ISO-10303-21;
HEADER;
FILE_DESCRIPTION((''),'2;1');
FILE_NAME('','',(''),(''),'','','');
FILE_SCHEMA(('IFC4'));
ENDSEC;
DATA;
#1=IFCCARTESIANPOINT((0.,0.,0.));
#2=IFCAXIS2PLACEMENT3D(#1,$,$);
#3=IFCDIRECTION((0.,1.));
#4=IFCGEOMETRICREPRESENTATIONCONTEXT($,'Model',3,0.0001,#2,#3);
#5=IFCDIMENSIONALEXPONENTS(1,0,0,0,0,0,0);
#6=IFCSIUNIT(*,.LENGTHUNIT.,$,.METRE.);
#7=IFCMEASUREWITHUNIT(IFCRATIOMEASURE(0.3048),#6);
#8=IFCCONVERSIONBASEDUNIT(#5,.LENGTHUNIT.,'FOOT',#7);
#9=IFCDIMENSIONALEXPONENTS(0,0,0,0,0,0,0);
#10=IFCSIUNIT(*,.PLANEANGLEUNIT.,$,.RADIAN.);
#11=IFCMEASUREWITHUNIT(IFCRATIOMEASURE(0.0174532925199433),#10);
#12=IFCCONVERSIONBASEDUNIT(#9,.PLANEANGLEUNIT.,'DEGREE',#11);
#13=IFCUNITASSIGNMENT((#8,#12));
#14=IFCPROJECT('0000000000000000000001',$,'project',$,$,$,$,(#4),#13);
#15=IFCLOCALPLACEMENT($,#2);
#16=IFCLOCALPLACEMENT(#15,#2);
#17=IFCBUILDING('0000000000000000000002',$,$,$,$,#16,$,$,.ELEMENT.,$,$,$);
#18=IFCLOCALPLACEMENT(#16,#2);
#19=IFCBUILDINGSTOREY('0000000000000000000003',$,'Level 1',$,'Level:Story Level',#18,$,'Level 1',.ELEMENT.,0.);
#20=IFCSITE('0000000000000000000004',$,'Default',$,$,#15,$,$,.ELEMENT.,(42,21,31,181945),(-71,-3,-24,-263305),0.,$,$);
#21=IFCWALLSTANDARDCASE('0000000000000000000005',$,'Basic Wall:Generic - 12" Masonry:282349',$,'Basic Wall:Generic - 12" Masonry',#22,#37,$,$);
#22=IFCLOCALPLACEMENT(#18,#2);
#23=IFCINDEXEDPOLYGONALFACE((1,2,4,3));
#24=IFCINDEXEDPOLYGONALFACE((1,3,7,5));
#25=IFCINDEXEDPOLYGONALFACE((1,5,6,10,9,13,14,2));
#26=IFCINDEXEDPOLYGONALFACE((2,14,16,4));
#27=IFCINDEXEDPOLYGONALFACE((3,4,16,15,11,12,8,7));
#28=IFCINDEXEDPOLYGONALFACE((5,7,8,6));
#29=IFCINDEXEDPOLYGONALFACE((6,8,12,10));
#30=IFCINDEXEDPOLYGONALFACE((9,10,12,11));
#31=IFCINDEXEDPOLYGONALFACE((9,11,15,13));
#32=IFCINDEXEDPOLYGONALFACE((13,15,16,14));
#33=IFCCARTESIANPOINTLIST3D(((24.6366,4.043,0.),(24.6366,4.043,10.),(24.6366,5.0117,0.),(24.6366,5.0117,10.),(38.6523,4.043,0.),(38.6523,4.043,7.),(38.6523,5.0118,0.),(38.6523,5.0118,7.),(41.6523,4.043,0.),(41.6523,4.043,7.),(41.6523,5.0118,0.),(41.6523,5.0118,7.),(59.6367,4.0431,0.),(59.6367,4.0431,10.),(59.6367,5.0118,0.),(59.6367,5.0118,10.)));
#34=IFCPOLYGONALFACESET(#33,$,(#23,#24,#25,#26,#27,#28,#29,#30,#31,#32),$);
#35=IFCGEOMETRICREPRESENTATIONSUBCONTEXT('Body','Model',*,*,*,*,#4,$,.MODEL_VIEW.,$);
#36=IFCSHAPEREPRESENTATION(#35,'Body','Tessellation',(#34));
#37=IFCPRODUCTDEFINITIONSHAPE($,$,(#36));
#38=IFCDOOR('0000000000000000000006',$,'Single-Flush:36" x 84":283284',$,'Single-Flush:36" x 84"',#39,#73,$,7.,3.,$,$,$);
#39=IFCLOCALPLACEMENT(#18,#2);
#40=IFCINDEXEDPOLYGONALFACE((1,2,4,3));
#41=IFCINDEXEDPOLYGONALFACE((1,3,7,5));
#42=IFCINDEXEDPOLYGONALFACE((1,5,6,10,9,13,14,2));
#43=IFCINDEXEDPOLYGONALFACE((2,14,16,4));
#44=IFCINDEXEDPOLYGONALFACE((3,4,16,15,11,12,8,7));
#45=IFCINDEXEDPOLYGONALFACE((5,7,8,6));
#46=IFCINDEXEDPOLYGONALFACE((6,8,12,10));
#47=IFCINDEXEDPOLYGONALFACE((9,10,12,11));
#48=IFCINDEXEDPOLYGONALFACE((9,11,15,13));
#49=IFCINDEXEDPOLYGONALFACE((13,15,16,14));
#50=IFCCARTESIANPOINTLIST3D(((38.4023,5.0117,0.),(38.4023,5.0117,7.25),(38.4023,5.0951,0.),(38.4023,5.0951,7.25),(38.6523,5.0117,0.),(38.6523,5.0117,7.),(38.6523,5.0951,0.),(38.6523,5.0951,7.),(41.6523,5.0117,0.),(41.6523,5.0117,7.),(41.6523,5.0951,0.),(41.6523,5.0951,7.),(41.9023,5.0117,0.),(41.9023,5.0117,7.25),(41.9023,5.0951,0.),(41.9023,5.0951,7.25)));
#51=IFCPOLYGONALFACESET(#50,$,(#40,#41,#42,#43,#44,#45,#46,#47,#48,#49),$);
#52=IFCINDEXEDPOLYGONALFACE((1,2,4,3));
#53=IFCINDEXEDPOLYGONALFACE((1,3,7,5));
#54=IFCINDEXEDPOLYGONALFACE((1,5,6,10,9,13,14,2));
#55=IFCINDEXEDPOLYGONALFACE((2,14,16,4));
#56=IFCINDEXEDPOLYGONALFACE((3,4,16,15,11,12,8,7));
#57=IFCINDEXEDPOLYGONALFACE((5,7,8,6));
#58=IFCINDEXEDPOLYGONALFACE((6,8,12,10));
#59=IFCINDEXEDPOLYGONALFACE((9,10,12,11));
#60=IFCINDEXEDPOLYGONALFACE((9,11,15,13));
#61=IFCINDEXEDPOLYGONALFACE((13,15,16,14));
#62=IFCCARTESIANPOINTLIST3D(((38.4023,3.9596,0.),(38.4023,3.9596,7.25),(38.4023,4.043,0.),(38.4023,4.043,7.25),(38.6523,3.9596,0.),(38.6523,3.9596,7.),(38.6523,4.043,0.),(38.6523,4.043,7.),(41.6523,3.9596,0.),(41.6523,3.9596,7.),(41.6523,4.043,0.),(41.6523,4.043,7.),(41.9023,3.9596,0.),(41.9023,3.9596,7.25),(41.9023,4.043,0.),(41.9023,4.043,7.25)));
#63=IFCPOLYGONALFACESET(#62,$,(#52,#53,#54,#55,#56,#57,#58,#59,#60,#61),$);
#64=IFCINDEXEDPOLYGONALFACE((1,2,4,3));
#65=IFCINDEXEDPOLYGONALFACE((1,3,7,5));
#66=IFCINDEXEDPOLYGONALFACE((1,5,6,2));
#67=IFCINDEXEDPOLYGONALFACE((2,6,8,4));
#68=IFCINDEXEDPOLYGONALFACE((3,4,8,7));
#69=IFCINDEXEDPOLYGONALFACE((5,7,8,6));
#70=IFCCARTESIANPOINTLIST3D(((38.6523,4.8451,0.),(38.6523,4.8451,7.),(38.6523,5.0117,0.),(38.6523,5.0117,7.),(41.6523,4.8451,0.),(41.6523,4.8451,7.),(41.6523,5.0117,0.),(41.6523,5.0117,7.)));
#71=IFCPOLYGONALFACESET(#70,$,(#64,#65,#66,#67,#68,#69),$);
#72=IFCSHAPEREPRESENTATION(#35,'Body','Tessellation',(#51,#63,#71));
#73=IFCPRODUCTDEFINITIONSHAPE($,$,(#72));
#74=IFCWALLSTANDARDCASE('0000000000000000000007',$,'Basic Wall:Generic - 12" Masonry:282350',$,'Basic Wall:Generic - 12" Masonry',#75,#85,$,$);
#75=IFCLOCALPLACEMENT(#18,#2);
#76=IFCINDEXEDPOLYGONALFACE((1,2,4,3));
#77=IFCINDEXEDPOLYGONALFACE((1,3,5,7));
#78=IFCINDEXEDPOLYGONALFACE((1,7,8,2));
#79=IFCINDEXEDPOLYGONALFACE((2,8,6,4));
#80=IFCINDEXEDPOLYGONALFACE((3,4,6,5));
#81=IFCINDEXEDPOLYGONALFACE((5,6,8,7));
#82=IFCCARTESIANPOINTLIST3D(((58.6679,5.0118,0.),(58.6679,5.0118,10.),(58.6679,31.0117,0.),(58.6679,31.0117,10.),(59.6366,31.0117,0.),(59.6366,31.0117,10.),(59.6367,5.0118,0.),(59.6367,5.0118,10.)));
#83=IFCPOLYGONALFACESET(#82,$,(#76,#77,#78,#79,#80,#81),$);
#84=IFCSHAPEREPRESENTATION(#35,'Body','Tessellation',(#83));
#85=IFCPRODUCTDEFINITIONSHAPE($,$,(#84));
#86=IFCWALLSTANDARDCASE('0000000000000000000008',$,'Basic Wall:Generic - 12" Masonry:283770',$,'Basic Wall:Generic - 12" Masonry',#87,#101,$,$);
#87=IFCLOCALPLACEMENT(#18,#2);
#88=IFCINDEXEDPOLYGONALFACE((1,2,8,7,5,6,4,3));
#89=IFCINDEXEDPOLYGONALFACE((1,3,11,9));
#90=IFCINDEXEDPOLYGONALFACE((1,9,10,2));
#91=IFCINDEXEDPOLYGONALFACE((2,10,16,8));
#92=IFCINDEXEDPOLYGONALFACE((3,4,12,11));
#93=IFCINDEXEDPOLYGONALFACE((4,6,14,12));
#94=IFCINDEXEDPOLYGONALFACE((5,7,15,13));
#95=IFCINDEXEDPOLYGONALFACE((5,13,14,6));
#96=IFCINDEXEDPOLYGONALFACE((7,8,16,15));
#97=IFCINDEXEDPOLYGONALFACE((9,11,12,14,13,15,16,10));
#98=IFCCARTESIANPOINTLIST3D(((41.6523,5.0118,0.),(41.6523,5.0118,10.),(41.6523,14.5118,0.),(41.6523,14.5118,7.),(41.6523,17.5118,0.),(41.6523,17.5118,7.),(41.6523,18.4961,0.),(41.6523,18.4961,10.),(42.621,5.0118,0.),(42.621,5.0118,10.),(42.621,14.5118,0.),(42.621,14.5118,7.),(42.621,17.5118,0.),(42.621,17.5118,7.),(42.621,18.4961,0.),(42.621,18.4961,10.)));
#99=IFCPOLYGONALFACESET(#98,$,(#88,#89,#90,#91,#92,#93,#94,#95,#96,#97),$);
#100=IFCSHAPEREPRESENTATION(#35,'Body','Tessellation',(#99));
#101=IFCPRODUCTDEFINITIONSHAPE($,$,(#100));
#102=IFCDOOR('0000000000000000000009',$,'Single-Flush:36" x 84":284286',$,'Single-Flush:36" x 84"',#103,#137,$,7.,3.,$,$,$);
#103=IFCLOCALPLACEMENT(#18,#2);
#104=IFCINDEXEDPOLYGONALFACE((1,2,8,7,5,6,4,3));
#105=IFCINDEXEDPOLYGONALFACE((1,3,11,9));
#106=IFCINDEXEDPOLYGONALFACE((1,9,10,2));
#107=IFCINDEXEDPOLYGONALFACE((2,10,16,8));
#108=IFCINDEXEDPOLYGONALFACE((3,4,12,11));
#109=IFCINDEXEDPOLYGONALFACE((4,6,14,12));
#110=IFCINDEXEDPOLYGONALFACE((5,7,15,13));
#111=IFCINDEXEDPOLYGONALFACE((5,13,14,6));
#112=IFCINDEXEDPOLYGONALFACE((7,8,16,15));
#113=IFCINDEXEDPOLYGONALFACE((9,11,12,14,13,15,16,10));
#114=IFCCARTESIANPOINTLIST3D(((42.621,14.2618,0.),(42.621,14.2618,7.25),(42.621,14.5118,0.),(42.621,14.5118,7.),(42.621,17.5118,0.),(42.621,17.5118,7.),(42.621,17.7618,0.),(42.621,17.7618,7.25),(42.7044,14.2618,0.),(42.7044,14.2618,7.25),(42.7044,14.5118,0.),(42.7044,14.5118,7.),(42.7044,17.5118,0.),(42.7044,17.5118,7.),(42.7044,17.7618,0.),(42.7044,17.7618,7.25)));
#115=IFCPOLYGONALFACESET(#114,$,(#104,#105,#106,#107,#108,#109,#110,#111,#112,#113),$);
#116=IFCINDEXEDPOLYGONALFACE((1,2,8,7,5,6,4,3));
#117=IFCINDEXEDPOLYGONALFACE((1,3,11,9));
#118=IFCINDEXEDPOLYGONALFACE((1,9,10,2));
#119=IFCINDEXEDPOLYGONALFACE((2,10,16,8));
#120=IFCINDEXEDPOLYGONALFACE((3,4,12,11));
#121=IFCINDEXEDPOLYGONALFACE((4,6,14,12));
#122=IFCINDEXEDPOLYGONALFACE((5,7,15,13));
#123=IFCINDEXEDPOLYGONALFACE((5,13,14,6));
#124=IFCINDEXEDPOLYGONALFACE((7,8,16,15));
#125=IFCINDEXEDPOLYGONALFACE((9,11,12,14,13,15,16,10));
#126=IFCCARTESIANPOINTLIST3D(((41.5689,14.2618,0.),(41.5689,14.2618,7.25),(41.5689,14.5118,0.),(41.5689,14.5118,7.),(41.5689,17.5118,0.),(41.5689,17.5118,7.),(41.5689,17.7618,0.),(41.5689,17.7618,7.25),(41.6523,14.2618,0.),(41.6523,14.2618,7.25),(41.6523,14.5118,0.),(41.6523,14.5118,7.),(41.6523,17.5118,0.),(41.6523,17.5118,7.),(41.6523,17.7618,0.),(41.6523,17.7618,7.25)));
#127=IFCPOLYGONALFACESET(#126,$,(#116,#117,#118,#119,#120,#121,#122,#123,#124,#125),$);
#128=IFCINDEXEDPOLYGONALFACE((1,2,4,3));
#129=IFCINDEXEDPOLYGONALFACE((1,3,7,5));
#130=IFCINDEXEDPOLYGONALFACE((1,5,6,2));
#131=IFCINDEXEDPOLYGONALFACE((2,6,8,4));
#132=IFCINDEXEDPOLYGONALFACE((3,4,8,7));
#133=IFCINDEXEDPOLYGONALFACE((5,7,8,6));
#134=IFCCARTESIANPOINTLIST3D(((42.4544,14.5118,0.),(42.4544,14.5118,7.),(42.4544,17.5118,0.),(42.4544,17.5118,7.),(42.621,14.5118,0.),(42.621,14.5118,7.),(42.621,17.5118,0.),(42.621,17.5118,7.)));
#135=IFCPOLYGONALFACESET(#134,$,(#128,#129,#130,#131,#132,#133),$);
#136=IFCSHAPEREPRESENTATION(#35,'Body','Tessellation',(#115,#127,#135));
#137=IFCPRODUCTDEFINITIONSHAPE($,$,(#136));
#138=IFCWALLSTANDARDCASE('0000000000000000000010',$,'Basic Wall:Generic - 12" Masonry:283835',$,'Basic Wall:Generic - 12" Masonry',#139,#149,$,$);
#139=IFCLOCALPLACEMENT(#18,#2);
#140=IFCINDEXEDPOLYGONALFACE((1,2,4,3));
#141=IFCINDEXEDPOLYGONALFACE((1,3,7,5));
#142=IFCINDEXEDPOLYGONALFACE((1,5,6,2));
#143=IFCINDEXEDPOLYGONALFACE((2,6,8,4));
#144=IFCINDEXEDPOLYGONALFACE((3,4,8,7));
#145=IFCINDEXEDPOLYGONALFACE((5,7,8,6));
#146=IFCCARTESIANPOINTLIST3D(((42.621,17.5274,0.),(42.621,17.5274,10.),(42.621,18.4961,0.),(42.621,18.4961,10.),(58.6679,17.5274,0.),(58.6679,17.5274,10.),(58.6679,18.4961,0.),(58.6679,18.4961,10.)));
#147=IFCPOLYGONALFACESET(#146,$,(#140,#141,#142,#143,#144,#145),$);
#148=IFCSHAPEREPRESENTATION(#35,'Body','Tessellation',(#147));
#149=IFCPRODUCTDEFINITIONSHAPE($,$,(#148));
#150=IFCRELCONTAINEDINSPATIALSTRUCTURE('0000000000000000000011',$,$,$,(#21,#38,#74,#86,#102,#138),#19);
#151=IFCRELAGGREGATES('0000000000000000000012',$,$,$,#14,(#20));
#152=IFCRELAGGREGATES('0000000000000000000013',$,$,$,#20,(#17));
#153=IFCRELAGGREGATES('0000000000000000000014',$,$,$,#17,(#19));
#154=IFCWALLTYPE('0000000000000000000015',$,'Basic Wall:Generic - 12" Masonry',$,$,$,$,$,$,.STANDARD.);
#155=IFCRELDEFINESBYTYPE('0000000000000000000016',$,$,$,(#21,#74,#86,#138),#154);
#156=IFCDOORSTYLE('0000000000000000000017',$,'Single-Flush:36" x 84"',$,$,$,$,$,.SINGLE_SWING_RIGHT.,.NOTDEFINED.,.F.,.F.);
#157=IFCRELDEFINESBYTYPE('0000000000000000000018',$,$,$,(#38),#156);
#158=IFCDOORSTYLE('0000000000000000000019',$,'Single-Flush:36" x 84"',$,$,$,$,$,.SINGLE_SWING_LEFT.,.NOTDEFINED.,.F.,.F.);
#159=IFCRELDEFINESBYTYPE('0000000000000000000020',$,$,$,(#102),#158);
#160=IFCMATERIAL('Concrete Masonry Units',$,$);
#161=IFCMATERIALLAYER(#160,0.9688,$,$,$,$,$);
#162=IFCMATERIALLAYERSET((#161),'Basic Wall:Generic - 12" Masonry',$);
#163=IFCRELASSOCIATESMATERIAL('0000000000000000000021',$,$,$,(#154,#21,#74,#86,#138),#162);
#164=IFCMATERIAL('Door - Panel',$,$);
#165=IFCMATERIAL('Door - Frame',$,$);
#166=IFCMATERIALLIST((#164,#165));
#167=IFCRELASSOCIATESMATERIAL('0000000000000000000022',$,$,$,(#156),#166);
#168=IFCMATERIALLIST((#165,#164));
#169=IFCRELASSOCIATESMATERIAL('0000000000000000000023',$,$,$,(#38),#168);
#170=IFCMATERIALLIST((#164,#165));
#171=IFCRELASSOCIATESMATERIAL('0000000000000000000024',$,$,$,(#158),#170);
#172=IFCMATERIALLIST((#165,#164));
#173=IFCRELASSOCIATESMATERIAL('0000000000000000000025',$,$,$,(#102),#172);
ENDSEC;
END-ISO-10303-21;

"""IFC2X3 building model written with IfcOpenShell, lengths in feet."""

from ifc_helpers import new_model, entity, si_unit, converted_unit, direction, frame, frame_2d, origin, place, context, subcontext, project, spatial, polyline, rectangle, outline, extrude, source, transform, mapped, material, material_list, layer, layer_set, layer_usage, type_object, type_shapes, element, fill, save


model = new_model("IFC2X3")

# Units and contexts
model_context = context("Model", 3, precision=0.0001, world=origin(), true_north=direction((0.0, 1.0)))
body_context = subcontext(model_context, "Body", "Model", "MODEL_VIEW")
ifc_project = project(units=[converted_unit("LENGTHUNIT", "FOOT", entity("IfcRatioMeasure", 0.3048), si_unit("LENGTHUNIT", "METRE"), dimensions=[1, 0, 0, 0, 0, 0, 0]), converted_unit("PLANEANGLEUNIT", "DEGREE", entity("IfcRatioMeasure", 0.0174532925199433), si_unit("PLANEANGLEUNIT", "RADIAN"), dimensions=[0, 0, 0, 0, 0, 0, 0])], contexts=[model_context])

# Site, building, storey
site_placement = place(None, origin())
site = spatial("IfcSite", under=ifc_project, at=site_placement, Name="Default", CompositionType="ELEMENT", RefLatitude=(42, 21, 31, 181945), RefLongitude=(-71, -3, -24, -263305), RefElevation=0.0)
building_placement = place(site_placement, origin())
building = spatial("IfcBuilding", under=site, at=building_placement, CompositionType="ELEMENT")
storey_placement = place(building_placement, origin())
storey = spatial("IfcBuildingStorey", under=building, at=storey_placement, Name="Level 1", ObjectType="Level:Story Level", LongName="Level 1", CompositionType="ELEMENT", Elevation=0.0)

# Shared definitions
ifc_material_1 = material(Name="Concrete Masonry Units")
ifc_layer_1 = layer(ifc_material_1, 0.9688)
ifc_layer_set_1 = layer_set([ifc_layer_1], Name="Basic Wall:Generic - 12\" Masonry")
wall_type = type_object("IfcWallType", Name="Basic Wall:Generic - 12\" Masonry", PredefinedType="STANDARD", material=ifc_layer_set_1)

# Wall, opening, door
ifc_layer_usage_1 = layer_usage(ifc_layer_set_1, "AXIS2", "NEGATIVE", 0.4844)
wall_1_placement = place(storey_placement, frame((59.6367, 4.5274, 0.0), z_axis=(0.0, 0.0, 1.0), x_axis=(-1.0, -0.000002, 0.0)))
wall_1 = element("IfcWallStandardCase", 1, at=wall_1_placement, inside=storey, type_object=wall_type, material=ifc_layer_usage_1, Name="Basic Wall:Generic - 12\" Masonry:282349", ObjectType="Basic Wall:Generic - 12\" Masonry", context=body_context, shape_type="SweptSolid", body=[
    extrude(rectangle(XDim=35.0, YDim=0.9688, at=frame_2d((17.5, 0.0), x_axis=(-1.0, 0.0))), origin(), (0.0, 0.0, 1.0), 10.0),
])
opening_1_placement = place(wall_1_placement, frame((20.9844, 0.4844, 0.0)))
opening_1 = element("IfcOpeningElement", 2, at=opening_1_placement, cuts=wall_1, ObjectType="Opening", context=body_context, shape_type="SweptSolid", body=[
    extrude(rectangle(XDim=3.0, YDim=7.0, at=frame_2d((3.5, 1.5), x_axis=(0.0, 1.0))), frame((0.0, 0.0, 0.0), z_axis=(0.000002, -1.0, 0.0), x_axis=(0.0, 0.0, 1.0)), (0.0, 0.0, 1.0), 0.9688),
])
ifc_material_2 = material(Name="Door - Frame")
ifc_material_3 = material(Name="Door - Panel")
ifc_material_list_1 = material_list([ifc_material_2, ifc_material_3])
ifc_material_list_2 = material_list([ifc_material_3, ifc_material_2])
door_style_1 = type_object("IfcDoorStyle", Name="Single-Flush:36\" x 84\"", ConstructionType="NOTDEFINED", OperationType="SINGLE_SWING_RIGHT", ParameterTakesPrecedence=False, Sizeable=False, material=ifc_material_list_2)
shared_shape_1 = source(origin(), body_context, "Body", "SweptSolid", [
    extrude(outline(polyline([(-1.75, -3.6875), (1.75, -3.6875), (1.75, 3.5625), (1.5, 3.5625), (1.5, -3.4375), (-1.5, -3.4375), (-1.5, 3.5625), (-1.75, 3.5625), (-1.75, -3.6875)])), frame((1.5, 0.9688, 3.5625), z_axis=(0.0, 1.0, 0.0), x_axis=(1.0, 0.0, 0.0)), (0.0, 0.0, 1.0), 0.0833),
    extrude(outline(polyline([(-3.6875, -1.75), (3.5625, -1.75), (3.5625, -1.5), (-3.4375, -1.5), (-3.4375, 1.5), (3.5625, 1.5), (3.5625, 1.75), (-3.6875, 1.75), (-3.6875, -1.75)])), frame((1.5, -0.0833, 3.5625), z_axis=(0.0, 1.0, 0.0), x_axis=(0.0, 0.0, -1.0)), (0.0, 0.0, 1.0), 0.0833),
    extrude(rectangle(XDim=0.1667, YDim=3.0, at=frame_2d((0.0, 0.0), x_axis=(1.0, 0.0))), frame((1.5, 0.8854, 0.0), z_axis=(0.0, 0.0, 1.0), x_axis=(0.0, 1.0, 0.0)), (0.0, 0.0, 1.0), 7.0),
])
type_shapes(door_style_1, [shared_shape_1])
door_1_placement = place(opening_1_placement, frame((0.0, 0.0, 0.0), z_axis=(0.0, 0.0, 1.0), x_axis=(-1.0, 0.0, 0.0)))
door_1 = element("IfcDoor", 3, at=door_1_placement, inside=storey, type_object=door_style_1, material=ifc_material_list_1, Name="Single-Flush:36\" x 84\":283284", ObjectType="Single-Flush:36\" x 84\"", OverallHeight=7.0, OverallWidth=3.0, context=body_context, shape_type="MappedRepresentation", body=[
    mapped(shared_shape_1, transform((0.0, 0.0, 0.0), scale=1.0)),
])
fill(opening_1, door_1)

# Wall
ifc_layer_usage_2 = layer_usage(ifc_layer_set_1, "AXIS2", "NEGATIVE", 0.4844)
wall_2_placement = place(storey_placement, frame((59.1523, 31.0117, 0.0), z_axis=(0.0, 0.0, 1.0), x_axis=(0.000002, -1.0, 0.0)))
element("IfcWallStandardCase", 4, at=wall_2_placement, inside=storey, type_object=wall_type, material=ifc_layer_usage_2, Name="Basic Wall:Generic - 12\" Masonry:282350", ObjectType="Basic Wall:Generic - 12\" Masonry", context=body_context, shape_type="SweptSolid", body=[
    extrude(rectangle(XDim=25.9999, YDim=0.9688, at=frame_2d((13.0, 0.0), x_axis=(-1.0, 0.0))), origin(), (0.0, 0.0, 1.0), 10.0),
])

# Wall, opening, door
ifc_layer_usage_3 = layer_usage(ifc_layer_set_1, "AXIS2", "NEGATIVE", 0.4844)
wall_3_placement = place(storey_placement, frame((42.1366, 5.0118, 0.0), z_axis=(0.0, 0.0, 1.0), x_axis=(0.0, 1.0, 0.0)))
wall_3 = element("IfcWallStandardCase", 5, at=wall_3_placement, inside=storey, type_object=wall_type, material=ifc_layer_usage_3, Name="Basic Wall:Generic - 12\" Masonry:283770", ObjectType="Basic Wall:Generic - 12\" Masonry", context=body_context, shape_type="SweptSolid", body=[
    extrude(rectangle(XDim=13.4844, YDim=0.9688, at=frame_2d((6.7422, 0.0), x_axis=(-1.0, 0.0))), origin(), (0.0, 0.0, 1.0), 10.0),
])
opening_2_placement = place(wall_3_placement, frame((12.5, 0.4844, 0.0)))
opening_2 = element("IfcOpeningElement", 6, at=opening_2_placement, cuts=wall_3, ObjectType="Opening", context=body_context, shape_type="SweptSolid", body=[
    extrude(rectangle(XDim=3.0, YDim=7.0, at=frame_2d((3.5, 1.5), x_axis=(0.0, -1.0))), frame((0.0, 0.0, 0.0), z_axis=(0.0, -1.0, 0.0), x_axis=(0.0, 0.0, 1.0)), (0.0, 0.0, 1.0), 0.9688),
])
ifc_material_list_3 = material_list([ifc_material_2, ifc_material_3])
ifc_material_list_4 = material_list([ifc_material_3, ifc_material_2])
door_style_2 = type_object("IfcDoorStyle", Name="Single-Flush:36\" x 84\"", ConstructionType="NOTDEFINED", OperationType="SINGLE_SWING_LEFT", ParameterTakesPrecedence=False, Sizeable=False, material=ifc_material_list_4)
shared_shape_2 = source(origin(), body_context, "Body", "SweptSolid", [
    extrude(outline(polyline([(-1.75, -3.6875), (1.75, -3.6875), (1.75, 3.5625), (1.5, 3.5625), (1.5, -3.4375), (-1.5, -3.4375), (-1.5, 3.5625), (-1.75, 3.5625), (-1.75, -3.6875)])), frame((1.5, 1.0521, 3.5625), z_axis=(0.0, -1.0, 0.0), x_axis=(-1.0, 0.0, 0.0)), (0.0, 0.0, 1.0), 0.0833),
    extrude(outline(polyline([(-3.6875, -1.75), (3.5625, -1.75), (3.5625, -1.5), (-3.4375, -1.5), (-3.4375, 1.5), (3.5625, 1.5), (3.5625, 1.75), (-3.6875, 1.75), (-3.6875, -1.75)])), frame((1.5, 0.0, 3.5625), z_axis=(0.0, -1.0, 0.0), x_axis=(0.0, 0.0, -1.0)), (0.0, 0.0, 1.0), 0.0833),
    extrude(rectangle(XDim=3.0, YDim=0.1667, at=frame_2d((0.0, 0.0), x_axis=(1.0, 0.0))), frame((1.5, 0.8854, 0.0)), (0.0, 0.0, 1.0), 7.0),
])
type_shapes(door_style_2, [shared_shape_2])
door_2_placement = place(opening_2_placement, frame((0.0, 0.0, 0.0), z_axis=(0.0, 0.0, 1.0), x_axis=(-1.0, 0.0, 0.0)))
door_2 = element("IfcDoor", 7, at=door_2_placement, inside=storey, type_object=door_style_2, material=ifc_material_list_3, Name="Single-Flush:36\" x 84\":284286", ObjectType="Single-Flush:36\" x 84\"", OverallHeight=7.0, OverallWidth=3.0, context=body_context, shape_type="MappedRepresentation", body=[
    mapped(shared_shape_2, transform((0.0, 0.0, 0.0), scale=1.0)),
])
fill(opening_2, door_2)

# Wall
ifc_layer_usage_4 = layer_usage(ifc_layer_set_1, "AXIS2", "NEGATIVE", 0.4844)
wall_4_placement = place(storey_placement, frame((42.621, 18.0118, 0.0)))
element("IfcWallStandardCase", 8, at=wall_4_placement, inside=storey, type_object=wall_type, material=ifc_layer_usage_4, Name="Basic Wall:Generic - 12\" Masonry:283835", ObjectType="Basic Wall:Generic - 12\" Masonry", context=body_context, shape_type="SweptSolid", body=[
    extrude(rectangle(XDim=16.0469, YDim=0.9688, at=frame_2d((8.0234, 0.0), x_axis=(-1.0, 0.0))), origin(), (0.0, 0.0, 1.0), 10.0),
])

save(model, "model.ifc")
